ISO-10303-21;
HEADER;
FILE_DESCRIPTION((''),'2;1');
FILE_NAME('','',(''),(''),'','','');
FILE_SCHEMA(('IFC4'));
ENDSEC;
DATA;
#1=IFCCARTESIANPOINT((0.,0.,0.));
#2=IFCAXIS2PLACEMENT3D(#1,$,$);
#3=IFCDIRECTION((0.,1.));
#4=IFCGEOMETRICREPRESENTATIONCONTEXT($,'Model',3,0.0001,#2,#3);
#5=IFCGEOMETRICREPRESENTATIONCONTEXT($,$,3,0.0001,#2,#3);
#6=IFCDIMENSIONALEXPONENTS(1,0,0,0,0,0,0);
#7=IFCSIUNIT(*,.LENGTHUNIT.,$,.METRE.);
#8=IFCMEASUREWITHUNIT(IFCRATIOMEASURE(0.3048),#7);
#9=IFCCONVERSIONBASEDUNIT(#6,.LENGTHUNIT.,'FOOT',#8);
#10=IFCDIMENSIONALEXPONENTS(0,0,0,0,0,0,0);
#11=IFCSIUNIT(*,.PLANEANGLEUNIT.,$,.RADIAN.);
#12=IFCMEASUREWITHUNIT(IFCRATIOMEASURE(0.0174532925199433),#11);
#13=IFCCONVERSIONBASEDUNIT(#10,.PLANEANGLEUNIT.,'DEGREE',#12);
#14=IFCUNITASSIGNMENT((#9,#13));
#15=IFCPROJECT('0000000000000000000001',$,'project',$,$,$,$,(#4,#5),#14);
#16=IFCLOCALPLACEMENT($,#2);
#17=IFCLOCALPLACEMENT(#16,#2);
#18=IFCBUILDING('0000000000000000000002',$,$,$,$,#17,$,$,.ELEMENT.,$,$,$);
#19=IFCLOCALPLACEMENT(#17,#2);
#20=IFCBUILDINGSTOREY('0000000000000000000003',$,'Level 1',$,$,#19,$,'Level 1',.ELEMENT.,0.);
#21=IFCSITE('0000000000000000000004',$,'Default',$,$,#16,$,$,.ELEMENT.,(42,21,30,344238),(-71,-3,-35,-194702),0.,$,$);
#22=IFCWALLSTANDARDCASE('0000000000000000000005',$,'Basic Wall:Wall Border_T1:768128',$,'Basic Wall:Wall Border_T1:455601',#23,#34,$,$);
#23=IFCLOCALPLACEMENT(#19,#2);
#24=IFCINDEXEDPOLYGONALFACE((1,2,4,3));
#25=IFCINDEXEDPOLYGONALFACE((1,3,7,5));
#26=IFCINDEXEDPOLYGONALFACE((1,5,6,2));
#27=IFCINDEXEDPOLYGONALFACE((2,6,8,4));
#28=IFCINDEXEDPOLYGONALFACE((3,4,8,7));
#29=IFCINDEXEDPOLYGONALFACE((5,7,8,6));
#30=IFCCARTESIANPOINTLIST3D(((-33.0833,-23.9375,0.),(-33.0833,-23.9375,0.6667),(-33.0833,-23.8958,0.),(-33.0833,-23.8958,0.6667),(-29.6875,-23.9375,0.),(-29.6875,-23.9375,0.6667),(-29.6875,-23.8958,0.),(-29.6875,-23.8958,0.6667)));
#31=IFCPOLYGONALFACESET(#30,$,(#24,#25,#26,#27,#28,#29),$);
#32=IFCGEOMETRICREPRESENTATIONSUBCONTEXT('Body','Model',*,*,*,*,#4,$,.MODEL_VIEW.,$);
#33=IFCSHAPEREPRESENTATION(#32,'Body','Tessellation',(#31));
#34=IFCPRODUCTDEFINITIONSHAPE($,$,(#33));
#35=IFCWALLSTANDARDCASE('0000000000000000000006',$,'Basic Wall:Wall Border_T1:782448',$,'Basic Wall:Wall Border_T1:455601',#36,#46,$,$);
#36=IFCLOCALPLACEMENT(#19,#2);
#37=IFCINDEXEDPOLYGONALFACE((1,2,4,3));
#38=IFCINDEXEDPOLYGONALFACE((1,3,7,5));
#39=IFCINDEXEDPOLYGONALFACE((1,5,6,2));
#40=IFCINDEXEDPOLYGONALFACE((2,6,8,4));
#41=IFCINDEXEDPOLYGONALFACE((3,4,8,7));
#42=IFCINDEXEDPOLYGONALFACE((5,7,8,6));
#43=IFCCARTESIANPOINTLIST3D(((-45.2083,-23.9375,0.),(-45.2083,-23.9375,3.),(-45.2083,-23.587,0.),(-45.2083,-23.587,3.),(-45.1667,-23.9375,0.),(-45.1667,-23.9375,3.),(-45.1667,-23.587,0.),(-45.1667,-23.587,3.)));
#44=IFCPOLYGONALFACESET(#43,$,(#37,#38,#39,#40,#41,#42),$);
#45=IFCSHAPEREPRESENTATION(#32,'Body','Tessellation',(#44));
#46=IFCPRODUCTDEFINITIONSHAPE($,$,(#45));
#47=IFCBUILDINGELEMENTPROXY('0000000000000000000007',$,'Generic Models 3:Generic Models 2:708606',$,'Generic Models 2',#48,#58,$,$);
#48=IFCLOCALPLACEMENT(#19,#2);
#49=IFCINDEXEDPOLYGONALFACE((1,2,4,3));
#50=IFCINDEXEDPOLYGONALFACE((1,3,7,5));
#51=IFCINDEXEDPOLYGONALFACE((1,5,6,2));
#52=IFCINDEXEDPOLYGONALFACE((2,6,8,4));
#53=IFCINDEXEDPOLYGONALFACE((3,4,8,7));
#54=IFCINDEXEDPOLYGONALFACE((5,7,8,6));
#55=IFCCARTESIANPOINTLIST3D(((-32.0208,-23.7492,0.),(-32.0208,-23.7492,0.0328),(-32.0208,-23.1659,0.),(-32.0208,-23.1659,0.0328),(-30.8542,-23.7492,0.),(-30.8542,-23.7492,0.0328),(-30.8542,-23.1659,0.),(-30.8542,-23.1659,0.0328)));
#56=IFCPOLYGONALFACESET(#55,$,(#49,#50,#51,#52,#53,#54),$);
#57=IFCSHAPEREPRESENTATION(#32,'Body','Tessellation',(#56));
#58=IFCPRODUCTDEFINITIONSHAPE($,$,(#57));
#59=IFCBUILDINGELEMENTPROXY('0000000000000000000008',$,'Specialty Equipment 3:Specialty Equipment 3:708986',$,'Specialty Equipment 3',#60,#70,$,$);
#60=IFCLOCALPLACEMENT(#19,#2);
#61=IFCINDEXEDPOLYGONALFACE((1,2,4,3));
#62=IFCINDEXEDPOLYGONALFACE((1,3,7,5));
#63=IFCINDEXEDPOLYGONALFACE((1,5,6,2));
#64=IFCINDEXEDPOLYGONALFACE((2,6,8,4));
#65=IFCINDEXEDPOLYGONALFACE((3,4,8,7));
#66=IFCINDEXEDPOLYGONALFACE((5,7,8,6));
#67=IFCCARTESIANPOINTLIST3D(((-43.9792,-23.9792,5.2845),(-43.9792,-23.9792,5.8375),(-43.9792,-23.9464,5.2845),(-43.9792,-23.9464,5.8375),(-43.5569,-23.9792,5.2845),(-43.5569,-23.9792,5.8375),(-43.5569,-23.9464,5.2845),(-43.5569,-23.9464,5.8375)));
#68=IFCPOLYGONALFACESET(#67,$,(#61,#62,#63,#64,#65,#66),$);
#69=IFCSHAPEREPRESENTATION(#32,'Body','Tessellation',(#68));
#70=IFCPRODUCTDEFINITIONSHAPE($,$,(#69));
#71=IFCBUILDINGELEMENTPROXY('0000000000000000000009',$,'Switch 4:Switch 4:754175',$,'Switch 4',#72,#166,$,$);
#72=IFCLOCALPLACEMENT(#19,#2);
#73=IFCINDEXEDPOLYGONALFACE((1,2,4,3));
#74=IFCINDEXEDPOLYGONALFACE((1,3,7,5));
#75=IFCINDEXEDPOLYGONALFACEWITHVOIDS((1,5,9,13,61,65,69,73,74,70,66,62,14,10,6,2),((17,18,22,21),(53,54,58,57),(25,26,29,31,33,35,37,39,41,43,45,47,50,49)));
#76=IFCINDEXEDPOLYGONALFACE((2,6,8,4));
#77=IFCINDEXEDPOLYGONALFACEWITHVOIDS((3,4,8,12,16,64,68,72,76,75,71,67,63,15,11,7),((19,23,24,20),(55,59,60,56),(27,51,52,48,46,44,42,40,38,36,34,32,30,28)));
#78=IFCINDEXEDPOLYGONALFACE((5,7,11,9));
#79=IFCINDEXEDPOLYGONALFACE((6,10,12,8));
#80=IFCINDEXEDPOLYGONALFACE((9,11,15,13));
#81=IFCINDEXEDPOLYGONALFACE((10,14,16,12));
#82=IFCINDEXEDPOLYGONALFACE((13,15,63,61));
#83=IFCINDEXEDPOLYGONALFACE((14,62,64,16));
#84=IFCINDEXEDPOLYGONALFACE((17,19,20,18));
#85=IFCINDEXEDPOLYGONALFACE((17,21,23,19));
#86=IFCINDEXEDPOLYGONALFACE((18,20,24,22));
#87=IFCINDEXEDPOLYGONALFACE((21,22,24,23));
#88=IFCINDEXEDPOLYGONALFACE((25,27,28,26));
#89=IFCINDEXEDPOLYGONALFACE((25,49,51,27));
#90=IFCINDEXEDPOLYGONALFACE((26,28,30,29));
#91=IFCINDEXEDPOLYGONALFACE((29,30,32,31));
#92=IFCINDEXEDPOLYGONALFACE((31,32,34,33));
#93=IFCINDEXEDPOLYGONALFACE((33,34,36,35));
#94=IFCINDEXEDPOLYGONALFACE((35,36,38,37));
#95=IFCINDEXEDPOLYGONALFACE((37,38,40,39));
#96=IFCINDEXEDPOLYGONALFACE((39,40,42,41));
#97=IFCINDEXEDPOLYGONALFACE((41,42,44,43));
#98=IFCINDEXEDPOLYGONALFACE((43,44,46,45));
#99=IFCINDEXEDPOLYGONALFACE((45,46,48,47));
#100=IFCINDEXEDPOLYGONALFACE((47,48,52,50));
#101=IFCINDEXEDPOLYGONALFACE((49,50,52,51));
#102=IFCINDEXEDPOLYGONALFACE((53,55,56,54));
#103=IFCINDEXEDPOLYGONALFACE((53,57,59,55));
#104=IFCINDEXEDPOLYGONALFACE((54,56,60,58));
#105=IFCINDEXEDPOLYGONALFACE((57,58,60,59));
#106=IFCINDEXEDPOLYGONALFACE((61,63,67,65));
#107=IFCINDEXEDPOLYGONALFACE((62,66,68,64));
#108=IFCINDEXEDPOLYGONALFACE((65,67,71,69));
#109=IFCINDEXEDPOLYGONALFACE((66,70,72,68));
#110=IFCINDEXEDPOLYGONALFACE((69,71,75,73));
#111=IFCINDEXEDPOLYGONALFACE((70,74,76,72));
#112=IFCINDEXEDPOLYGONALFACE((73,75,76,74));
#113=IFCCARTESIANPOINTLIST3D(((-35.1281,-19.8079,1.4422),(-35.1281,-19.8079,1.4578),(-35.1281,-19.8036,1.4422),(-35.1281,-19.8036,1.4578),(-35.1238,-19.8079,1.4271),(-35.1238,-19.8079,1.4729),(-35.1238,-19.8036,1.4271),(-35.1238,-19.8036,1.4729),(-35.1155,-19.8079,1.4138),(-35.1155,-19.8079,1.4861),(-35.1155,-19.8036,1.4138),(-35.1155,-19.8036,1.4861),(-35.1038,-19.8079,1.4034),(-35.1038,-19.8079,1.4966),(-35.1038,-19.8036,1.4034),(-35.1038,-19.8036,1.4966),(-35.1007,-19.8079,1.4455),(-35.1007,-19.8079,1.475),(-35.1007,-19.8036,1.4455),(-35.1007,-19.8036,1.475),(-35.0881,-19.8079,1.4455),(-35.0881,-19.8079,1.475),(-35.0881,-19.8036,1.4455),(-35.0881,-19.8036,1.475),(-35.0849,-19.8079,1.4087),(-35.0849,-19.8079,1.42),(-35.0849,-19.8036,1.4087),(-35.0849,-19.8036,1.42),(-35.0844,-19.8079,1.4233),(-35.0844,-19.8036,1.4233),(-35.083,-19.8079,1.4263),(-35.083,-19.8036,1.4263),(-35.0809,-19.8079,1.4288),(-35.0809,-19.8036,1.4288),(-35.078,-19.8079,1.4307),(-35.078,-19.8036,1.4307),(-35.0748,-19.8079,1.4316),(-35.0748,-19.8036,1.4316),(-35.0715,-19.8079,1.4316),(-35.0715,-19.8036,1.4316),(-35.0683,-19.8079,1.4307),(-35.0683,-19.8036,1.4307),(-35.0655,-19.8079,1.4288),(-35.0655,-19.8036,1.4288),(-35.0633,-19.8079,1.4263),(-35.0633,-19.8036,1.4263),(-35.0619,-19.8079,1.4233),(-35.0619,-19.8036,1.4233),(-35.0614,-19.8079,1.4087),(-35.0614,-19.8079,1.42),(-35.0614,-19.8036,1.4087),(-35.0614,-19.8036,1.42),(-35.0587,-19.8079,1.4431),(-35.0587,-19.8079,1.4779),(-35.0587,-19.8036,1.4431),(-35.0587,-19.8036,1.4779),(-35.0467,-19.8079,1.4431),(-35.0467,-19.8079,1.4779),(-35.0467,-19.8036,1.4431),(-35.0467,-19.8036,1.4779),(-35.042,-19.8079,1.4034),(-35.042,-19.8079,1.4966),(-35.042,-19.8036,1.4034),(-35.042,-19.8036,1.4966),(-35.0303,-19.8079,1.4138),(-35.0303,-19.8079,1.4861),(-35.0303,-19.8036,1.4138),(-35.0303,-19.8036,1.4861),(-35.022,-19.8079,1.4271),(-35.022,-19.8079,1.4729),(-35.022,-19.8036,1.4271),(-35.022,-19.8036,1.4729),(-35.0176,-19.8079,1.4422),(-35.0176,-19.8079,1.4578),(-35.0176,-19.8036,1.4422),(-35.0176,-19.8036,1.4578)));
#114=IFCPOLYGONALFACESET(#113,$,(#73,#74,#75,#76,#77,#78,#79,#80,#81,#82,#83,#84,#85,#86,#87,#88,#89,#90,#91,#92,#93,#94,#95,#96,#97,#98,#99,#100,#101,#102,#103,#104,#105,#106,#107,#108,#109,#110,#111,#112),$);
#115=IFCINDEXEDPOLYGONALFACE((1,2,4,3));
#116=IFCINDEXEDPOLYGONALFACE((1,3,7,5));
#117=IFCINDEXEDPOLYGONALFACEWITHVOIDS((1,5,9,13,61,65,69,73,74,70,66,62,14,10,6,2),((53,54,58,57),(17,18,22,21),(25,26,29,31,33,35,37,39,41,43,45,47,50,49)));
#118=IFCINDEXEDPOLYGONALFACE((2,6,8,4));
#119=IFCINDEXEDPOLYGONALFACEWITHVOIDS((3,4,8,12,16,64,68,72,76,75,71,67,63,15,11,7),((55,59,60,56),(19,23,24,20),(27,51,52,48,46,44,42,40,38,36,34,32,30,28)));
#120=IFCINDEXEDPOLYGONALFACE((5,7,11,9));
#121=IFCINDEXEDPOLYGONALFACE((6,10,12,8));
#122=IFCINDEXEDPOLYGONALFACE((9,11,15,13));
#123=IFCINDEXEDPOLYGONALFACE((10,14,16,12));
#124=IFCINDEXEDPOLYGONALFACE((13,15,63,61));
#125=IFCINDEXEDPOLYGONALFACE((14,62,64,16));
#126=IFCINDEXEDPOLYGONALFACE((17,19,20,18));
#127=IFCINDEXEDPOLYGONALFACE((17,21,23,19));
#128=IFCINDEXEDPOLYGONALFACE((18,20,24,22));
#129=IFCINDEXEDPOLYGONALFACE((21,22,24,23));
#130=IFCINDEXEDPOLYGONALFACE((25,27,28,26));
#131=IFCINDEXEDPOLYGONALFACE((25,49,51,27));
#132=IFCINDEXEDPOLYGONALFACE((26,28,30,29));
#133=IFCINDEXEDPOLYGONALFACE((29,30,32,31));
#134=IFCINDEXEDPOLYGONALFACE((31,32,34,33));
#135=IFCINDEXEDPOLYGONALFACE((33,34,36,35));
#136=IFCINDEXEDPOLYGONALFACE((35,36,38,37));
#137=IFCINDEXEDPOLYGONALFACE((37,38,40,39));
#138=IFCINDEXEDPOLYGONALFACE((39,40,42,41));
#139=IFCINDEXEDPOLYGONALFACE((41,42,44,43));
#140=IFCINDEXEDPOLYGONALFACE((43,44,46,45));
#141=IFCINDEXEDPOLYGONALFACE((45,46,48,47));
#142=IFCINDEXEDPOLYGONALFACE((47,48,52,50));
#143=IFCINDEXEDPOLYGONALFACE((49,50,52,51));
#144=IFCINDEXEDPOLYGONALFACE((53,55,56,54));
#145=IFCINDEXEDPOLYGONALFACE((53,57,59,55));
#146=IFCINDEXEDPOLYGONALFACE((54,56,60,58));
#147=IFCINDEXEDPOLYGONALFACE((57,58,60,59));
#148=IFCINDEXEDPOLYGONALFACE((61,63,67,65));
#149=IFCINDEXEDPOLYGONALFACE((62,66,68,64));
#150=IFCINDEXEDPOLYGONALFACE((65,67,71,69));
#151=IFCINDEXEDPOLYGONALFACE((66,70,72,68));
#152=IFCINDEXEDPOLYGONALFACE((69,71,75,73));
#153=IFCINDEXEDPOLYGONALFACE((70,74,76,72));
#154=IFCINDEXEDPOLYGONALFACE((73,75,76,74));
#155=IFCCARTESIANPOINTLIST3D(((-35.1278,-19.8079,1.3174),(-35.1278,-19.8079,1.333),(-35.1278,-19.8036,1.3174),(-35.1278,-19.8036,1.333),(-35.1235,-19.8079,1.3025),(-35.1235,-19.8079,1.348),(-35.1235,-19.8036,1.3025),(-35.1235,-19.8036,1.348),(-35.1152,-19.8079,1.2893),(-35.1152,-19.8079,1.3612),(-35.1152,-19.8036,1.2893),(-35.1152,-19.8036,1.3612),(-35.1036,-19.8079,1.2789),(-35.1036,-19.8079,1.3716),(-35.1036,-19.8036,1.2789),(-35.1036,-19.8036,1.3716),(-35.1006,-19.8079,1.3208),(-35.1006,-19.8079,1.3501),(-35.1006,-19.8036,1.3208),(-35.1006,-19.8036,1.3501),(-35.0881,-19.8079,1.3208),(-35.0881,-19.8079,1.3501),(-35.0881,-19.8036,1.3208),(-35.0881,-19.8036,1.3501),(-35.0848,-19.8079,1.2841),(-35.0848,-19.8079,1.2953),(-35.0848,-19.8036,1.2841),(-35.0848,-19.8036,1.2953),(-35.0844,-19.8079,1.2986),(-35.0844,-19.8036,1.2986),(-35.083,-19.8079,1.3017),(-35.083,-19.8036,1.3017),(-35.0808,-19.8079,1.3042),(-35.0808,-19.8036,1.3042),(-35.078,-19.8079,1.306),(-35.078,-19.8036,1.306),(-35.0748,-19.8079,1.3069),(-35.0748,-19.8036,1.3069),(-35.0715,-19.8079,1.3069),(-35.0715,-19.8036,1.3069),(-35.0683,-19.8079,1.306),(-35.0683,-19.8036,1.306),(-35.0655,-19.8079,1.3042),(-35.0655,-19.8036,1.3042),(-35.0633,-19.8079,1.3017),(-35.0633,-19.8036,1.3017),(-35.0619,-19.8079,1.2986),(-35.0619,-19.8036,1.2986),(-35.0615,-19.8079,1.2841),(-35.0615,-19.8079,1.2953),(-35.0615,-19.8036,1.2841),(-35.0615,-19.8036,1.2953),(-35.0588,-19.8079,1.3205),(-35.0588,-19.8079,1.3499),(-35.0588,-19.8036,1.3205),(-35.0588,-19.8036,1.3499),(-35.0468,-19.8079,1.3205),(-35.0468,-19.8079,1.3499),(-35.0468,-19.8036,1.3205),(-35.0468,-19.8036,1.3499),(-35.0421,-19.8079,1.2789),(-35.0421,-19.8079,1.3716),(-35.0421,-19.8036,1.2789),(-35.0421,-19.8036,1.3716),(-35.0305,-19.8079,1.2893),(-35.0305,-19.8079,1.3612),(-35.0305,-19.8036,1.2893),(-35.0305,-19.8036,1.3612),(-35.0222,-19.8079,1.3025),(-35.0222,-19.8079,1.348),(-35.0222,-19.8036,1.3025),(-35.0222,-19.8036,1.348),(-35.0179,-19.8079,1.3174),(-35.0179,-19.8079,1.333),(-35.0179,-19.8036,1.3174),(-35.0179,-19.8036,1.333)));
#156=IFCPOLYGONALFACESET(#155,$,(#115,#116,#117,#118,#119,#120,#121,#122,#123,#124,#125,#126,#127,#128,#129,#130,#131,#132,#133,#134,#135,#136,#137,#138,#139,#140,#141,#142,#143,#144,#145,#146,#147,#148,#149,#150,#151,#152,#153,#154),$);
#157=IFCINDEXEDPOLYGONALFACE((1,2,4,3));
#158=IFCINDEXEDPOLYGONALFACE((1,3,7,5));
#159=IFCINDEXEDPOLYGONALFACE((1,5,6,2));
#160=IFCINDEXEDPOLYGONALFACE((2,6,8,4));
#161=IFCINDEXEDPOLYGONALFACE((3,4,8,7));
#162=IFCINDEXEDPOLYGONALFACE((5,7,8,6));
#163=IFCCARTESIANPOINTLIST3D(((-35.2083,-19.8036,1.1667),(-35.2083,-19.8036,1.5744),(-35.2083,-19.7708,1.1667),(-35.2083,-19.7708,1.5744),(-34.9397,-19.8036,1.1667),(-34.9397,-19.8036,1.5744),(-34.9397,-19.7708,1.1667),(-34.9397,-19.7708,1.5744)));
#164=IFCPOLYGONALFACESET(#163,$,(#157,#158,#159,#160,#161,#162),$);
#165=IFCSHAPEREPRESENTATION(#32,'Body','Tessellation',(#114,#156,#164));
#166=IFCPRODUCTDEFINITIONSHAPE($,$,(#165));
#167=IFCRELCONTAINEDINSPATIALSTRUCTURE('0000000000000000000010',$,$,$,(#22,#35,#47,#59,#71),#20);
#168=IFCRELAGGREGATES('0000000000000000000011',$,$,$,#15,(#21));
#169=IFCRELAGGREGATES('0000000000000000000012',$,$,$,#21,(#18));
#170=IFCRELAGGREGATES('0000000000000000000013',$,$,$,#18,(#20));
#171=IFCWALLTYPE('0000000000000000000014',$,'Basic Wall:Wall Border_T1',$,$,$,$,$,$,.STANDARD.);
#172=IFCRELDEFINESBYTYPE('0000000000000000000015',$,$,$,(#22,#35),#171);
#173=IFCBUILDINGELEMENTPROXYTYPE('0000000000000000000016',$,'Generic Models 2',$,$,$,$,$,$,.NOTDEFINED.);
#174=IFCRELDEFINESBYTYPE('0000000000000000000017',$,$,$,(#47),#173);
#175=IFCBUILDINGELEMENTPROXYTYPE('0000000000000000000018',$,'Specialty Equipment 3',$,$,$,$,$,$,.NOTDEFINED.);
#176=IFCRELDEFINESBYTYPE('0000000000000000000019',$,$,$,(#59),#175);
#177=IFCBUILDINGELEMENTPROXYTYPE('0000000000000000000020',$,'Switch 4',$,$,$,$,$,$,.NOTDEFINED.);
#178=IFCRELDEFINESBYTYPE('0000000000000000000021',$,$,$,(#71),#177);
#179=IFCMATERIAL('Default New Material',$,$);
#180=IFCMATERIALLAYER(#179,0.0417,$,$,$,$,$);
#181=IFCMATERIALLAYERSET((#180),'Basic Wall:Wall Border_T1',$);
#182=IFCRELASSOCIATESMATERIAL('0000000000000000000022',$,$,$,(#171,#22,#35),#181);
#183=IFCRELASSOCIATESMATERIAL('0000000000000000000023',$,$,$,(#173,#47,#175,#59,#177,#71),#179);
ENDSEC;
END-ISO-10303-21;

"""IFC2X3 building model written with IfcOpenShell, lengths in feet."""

from ifc_helpers import new_model, entity, si_unit, converted_unit, direction, frame, frame_2d, origin, origin_2d_with_axis, place, context, subcontext, project, spatial, polyline, circle_curve, parameter, trimmed, segment, composite_curve, rectangle, outline, extrude, source, transform, mapped, material, layer, layer_set, layer_usage, type_object, type_shapes, element, save


model = new_model("IFC2X3")

# Units and contexts
model_context = context("Model", 3, precision=0.0001, world=origin(), true_north=direction((0.0, 1.0)))
context_of_model = context(None, 3, precision=0.0001, world=origin(), true_north=direction((0.0, 1.0)))
body_context = subcontext(model_context, "Body", "Model", "MODEL_VIEW")
ifc_project = project(units=[converted_unit("LENGTHUNIT", "FOOT", entity("IfcRatioMeasure", 0.3048), si_unit("LENGTHUNIT", "METRE"), dimensions=[1, 0, 0, 0, 0, 0, 0]), converted_unit("PLANEANGLEUNIT", "DEGREE", entity("IfcRatioMeasure", 0.0174532925199433), si_unit("PLANEANGLEUNIT", "RADIAN"), dimensions=[0, 0, 0, 0, 0, 0, 0])], contexts=[model_context, context_of_model])

# Site, building, storey
site_placement = place(None, origin())
site = spatial("IfcSite", under=ifc_project, at=site_placement, Name="Default", CompositionType="ELEMENT", RefLatitude=(42, 21, 30, 344238), RefLongitude=(-71, -3, -35, -194702), RefElevation=0.0)
building_placement = place(site_placement, origin())
building = spatial("IfcBuilding", under=site, at=building_placement, CompositionType="ELEMENT")
storey_placement = place(building_placement, origin())
storey = spatial("IfcBuildingStorey", under=building, at=storey_placement, Name="Level 1", LongName="Level 1", CompositionType="ELEMENT", Elevation=0.0)

# Shared definitions
ifc_material_1 = material(Name="Default New Material")

# Walls
ifc_layer_1 = layer(ifc_material_1, 0.0417)
ifc_layer_set_1 = layer_set([ifc_layer_1], Name="Basic Wall:Wall Border_T1")
wall_type_1 = type_object("IfcWallType", Name="Basic Wall:Wall Border_T1", PredefinedType="STANDARD", material=ifc_layer_set_1)
ifc_layer_usage_1 = layer_usage(ifc_layer_set_1, "AXIS2", "NEGATIVE", 0.0208)
wall_1_placement = place(storey_placement, frame((-33.0833, -23.9167, 0.0)))
element("IfcWallStandardCase", 1, at=wall_1_placement, inside=storey, type_object=wall_type_1, material=ifc_layer_usage_1, Name="Basic Wall:Wall Border_T1:768128", ObjectType="Basic Wall:Wall Border_T1:455601", context=body_context, shape_type="SweptSolid", body=[
    extrude(rectangle(XDim=3.3958, YDim=0.0417, at=frame_2d((1.6979, 0.0), x_axis=(-1.0, 0.0))), origin(), (0.0, 0.0, 1.0), 0.6667),
])
ifc_layer_usage_2 = layer_usage(ifc_layer_set_1, "AXIS2", "NEGATIVE", 0.0208)
wall_2_placement = place(storey_placement, frame((-45.1875, -23.587, 0.0), z_axis=(0.0, 0.0, 1.0), x_axis=(0.0, -1.0, 0.0)))
element("IfcWallStandardCase", 2, at=wall_2_placement, inside=storey, type_object=wall_type_1, material=ifc_layer_usage_2, Name="Basic Wall:Wall Border_T1:782448", ObjectType="Basic Wall:Wall Border_T1:455601", context=body_context, shape_type="SweptSolid", body=[
    extrude(rectangle(XDim=0.3505, YDim=0.0417, at=frame_2d((0.1753, 0.0), x_axis=(-1.0, 0.0))), origin(), (0.0, 0.0, 1.0), 3.0),
])

# Building element proxies
building_element_proxy_type_1 = type_object("IfcBuildingElementProxyType", Name="Generic Models 2", PredefinedType="NOTDEFINED", material=ifc_material_1)
shared_shape_1 = source(origin(), body_context, "Body", "SweptSolid", [
    extrude(rectangle(XDim=1.1667, YDim=0.5833, at=frame_2d((0.0, 0.0), x_axis=(1.0, 0.0))), frame((0.5833, 0.2917, 0.0), z_axis=(0.0, 0.0, 1.0), x_axis=(-1.0, 0.0, 0.0)), (0.0, 0.0, 1.0), 0.0328),
])
type_shapes(building_element_proxy_type_1, [shared_shape_1])
proxy_1_placement = place(storey_placement, frame((-32.0208, -23.7492, 0.0)))
element("IfcBuildingElementProxy", 3, at=proxy_1_placement, inside=storey, type_object=building_element_proxy_type_1, material=ifc_material_1, Name="Generic Models 3:Generic Models 2:708606", ObjectType="Generic Models 2", context=body_context, shape_type="MappedRepresentation", body=[
    mapped(shared_shape_1, transform((0.0, 0.0, 0.0), scale=1.0)),
])
building_element_proxy_type_2 = type_object("IfcBuildingElementProxyType", Name="Specialty Equipment 3", PredefinedType="NOTDEFINED", material=ifc_material_1)
shared_shape_2 = source(origin(), body_context, "Body", "SweptSolid", [
    extrude(rectangle(XDim=0.0328, YDim=0.4223, at=frame_2d((0.0, 0.0), x_axis=(1.0, 0.0))), frame((0.2111, 0.0164, 0.0), z_axis=(0.0, 0.0, 1.0), x_axis=(0.0, -1.0, 0.0)), (0.0, 0.0, 1.0), 0.5529),
])
type_shapes(building_element_proxy_type_2, [shared_shape_2])
proxy_2_placement = place(storey_placement, frame((-43.9792, -23.9792, 5.2845)))
element("IfcBuildingElementProxy", 4, at=proxy_2_placement, inside=storey, type_object=building_element_proxy_type_2, material=ifc_material_1, Name="Specialty Equipment 3:Specialty Equipment 3:708986", ObjectType="Specialty Equipment 3", context=body_context, shape_type="MappedRepresentation", body=[
    mapped(shared_shape_2, transform((0.0, 0.0, 0.0), scale=1.0)),
])
building_element_proxy_type_3 = type_object("IfcBuildingElementProxyType", Name="Switch 4", PredefinedType="NOTDEFINED", material=ifc_material_1)
shared_shape_3 = source(origin(), body_context, "Body", "SweptSolid", [
    extrude(outline(composite_curve([segment(polyline([(-0.0309, -0.0466), (0.0309, -0.0466)]), True, "CONTINUOUS"), segment(trimmed(circle_curve(frame_2d((-0.0003, 0.0), x_axis=(-1.0, 0.0)), 0.0561), [parameter(123.794741)], [parameter(236.205259)], True, "PARAMETER"), True, "CONTINUOUS"), segment(polyline([(0.0309, 0.0466), (-0.0309, 0.0466)]), True, "CONTINUOUS"), segment(trimmed(circle_curve(frame_2d((0.0003, 0.0), x_axis=(1.0, 0.0)), 0.0561), [parameter(123.794741)], [parameter(236.205259)], True, "PARAMETER"), True, "CONTINUOUS")], self_intersect=False), holes=[polyline([(0.0142, 0.0279), (0.0262, 0.0279), (0.0262, -0.0069), (0.0142, -0.0069), (0.0142, 0.0279)]), polyline([(-0.0153, 0.025), (-0.0153, -0.0045), (-0.0278, -0.0045), (-0.0278, 0.025), (-0.0153, 0.025)]), composite_curve([segment(polyline([(-0.012, -0.0413), (-0.012, -0.03)]), True, "CONTINUOUS"), segment(trimmed(circle_curve(frame_2d((-0.0003, -0.03), x_axis=(-1.0, 0.0)), 0.0117), [parameter(180.0)], [parameter(0.0)], True, "PARAMETER"), False, "CONTINUOUS"), segment(polyline([(0.0115, -0.03), (0.0115, -0.0413)]), True, "CONTINUOUS"), segment(polyline([(0.0115, -0.0413), (-0.012, -0.0413)]), True, "CONTINUOUS")], self_intersect=False)]), frame((-0.0011, 0.0328, 0.2833), z_axis=(0.0, 1.0, 0.0), x_axis=(-1.0, 0.0, 0.0)), (0.0, 0.0, 1.0), 0.0042),
    extrude(outline(composite_curve([segment(polyline([(-0.0308, -0.0464), (0.0308, -0.0464)]), True, "CONTINUOUS"), segment(trimmed(circle_curve(frame_2d((-0.0003, 0.0), x_axis=(-1.0, 0.0)), 0.0558), [parameter(123.794741)], [parameter(236.205259)], True, "PARAMETER"), True, "CONTINUOUS"), segment(polyline([(0.0308, 0.0464), (-0.0308, 0.0464)]), True, "CONTINUOUS"), segment(trimmed(circle_curve(frame_2d((0.0003, 0.0), x_axis=(1.0, 0.0)), 0.0558), [parameter(123.794741)], [parameter(236.205259)], True, "PARAMETER"), True, "CONTINUOUS")], self_intersect=False), holes=[polyline([(0.0141, 0.0247), (0.026, 0.0247), (0.026, -0.0047), (0.0141, -0.0047), (0.0141, 0.0247)]), polyline([(-0.0152, 0.0249), (-0.0152, -0.0045), (-0.0277, -0.0045), (-0.0277, 0.0249), (-0.0152, 0.0249)]), composite_curve([segment(polyline([(-0.012, -0.0411), (-0.012, -0.0299)]), True, "CONTINUOUS"), segment(trimmed(circle_curve(frame_2d((-0.0003, -0.0299), x_axis=(-1.0, 0.0)), 0.0117), [parameter(180.0)], [parameter(0.0)], True, "PARAMETER"), False, "CONTINUOUS"), segment(polyline([(0.0114, -0.0299), (0.0114, -0.0411)]), True, "CONTINUOUS"), segment(polyline([(0.0114, -0.0411), (-0.012, -0.0411)]), True, "CONTINUOUS")], self_intersect=False)]), frame((-0.0011, 0.0328, 0.1586), z_axis=(0.0, 1.0, 0.0), x_axis=(-1.0, 0.0, 0.0)), (0.0, 0.0, 1.0), 0.0042),
    extrude(rectangle(XDim=0.0328, YDim=0.2687, at=origin_2d_with_axis()), frame((0.0, 0.0164, 0.0), z_axis=(0.0, 0.0, 1.0), x_axis=(0.0, -1.0, 0.0)), (0.0, 0.0, 1.0), 0.4078),
])
type_shapes(building_element_proxy_type_3, [shared_shape_3])
proxy_3_placement = place(storey_placement, frame((-35.074, -19.7708, 1.1667), z_axis=(0.0, 0.0, 1.0), x_axis=(-1.0, 0.0, 0.0)))
element("IfcBuildingElementProxy", 5, at=proxy_3_placement, inside=storey, type_object=building_element_proxy_type_3, material=ifc_material_1, Name="Switch 4:Switch 4:754175", ObjectType="Switch 4", context=body_context, shape_type="MappedRepresentation", body=[
    mapped(shared_shape_3, transform((0.0, 0.0, 0.0), scale=1.0)),
])

save(model, "model.ifc")
